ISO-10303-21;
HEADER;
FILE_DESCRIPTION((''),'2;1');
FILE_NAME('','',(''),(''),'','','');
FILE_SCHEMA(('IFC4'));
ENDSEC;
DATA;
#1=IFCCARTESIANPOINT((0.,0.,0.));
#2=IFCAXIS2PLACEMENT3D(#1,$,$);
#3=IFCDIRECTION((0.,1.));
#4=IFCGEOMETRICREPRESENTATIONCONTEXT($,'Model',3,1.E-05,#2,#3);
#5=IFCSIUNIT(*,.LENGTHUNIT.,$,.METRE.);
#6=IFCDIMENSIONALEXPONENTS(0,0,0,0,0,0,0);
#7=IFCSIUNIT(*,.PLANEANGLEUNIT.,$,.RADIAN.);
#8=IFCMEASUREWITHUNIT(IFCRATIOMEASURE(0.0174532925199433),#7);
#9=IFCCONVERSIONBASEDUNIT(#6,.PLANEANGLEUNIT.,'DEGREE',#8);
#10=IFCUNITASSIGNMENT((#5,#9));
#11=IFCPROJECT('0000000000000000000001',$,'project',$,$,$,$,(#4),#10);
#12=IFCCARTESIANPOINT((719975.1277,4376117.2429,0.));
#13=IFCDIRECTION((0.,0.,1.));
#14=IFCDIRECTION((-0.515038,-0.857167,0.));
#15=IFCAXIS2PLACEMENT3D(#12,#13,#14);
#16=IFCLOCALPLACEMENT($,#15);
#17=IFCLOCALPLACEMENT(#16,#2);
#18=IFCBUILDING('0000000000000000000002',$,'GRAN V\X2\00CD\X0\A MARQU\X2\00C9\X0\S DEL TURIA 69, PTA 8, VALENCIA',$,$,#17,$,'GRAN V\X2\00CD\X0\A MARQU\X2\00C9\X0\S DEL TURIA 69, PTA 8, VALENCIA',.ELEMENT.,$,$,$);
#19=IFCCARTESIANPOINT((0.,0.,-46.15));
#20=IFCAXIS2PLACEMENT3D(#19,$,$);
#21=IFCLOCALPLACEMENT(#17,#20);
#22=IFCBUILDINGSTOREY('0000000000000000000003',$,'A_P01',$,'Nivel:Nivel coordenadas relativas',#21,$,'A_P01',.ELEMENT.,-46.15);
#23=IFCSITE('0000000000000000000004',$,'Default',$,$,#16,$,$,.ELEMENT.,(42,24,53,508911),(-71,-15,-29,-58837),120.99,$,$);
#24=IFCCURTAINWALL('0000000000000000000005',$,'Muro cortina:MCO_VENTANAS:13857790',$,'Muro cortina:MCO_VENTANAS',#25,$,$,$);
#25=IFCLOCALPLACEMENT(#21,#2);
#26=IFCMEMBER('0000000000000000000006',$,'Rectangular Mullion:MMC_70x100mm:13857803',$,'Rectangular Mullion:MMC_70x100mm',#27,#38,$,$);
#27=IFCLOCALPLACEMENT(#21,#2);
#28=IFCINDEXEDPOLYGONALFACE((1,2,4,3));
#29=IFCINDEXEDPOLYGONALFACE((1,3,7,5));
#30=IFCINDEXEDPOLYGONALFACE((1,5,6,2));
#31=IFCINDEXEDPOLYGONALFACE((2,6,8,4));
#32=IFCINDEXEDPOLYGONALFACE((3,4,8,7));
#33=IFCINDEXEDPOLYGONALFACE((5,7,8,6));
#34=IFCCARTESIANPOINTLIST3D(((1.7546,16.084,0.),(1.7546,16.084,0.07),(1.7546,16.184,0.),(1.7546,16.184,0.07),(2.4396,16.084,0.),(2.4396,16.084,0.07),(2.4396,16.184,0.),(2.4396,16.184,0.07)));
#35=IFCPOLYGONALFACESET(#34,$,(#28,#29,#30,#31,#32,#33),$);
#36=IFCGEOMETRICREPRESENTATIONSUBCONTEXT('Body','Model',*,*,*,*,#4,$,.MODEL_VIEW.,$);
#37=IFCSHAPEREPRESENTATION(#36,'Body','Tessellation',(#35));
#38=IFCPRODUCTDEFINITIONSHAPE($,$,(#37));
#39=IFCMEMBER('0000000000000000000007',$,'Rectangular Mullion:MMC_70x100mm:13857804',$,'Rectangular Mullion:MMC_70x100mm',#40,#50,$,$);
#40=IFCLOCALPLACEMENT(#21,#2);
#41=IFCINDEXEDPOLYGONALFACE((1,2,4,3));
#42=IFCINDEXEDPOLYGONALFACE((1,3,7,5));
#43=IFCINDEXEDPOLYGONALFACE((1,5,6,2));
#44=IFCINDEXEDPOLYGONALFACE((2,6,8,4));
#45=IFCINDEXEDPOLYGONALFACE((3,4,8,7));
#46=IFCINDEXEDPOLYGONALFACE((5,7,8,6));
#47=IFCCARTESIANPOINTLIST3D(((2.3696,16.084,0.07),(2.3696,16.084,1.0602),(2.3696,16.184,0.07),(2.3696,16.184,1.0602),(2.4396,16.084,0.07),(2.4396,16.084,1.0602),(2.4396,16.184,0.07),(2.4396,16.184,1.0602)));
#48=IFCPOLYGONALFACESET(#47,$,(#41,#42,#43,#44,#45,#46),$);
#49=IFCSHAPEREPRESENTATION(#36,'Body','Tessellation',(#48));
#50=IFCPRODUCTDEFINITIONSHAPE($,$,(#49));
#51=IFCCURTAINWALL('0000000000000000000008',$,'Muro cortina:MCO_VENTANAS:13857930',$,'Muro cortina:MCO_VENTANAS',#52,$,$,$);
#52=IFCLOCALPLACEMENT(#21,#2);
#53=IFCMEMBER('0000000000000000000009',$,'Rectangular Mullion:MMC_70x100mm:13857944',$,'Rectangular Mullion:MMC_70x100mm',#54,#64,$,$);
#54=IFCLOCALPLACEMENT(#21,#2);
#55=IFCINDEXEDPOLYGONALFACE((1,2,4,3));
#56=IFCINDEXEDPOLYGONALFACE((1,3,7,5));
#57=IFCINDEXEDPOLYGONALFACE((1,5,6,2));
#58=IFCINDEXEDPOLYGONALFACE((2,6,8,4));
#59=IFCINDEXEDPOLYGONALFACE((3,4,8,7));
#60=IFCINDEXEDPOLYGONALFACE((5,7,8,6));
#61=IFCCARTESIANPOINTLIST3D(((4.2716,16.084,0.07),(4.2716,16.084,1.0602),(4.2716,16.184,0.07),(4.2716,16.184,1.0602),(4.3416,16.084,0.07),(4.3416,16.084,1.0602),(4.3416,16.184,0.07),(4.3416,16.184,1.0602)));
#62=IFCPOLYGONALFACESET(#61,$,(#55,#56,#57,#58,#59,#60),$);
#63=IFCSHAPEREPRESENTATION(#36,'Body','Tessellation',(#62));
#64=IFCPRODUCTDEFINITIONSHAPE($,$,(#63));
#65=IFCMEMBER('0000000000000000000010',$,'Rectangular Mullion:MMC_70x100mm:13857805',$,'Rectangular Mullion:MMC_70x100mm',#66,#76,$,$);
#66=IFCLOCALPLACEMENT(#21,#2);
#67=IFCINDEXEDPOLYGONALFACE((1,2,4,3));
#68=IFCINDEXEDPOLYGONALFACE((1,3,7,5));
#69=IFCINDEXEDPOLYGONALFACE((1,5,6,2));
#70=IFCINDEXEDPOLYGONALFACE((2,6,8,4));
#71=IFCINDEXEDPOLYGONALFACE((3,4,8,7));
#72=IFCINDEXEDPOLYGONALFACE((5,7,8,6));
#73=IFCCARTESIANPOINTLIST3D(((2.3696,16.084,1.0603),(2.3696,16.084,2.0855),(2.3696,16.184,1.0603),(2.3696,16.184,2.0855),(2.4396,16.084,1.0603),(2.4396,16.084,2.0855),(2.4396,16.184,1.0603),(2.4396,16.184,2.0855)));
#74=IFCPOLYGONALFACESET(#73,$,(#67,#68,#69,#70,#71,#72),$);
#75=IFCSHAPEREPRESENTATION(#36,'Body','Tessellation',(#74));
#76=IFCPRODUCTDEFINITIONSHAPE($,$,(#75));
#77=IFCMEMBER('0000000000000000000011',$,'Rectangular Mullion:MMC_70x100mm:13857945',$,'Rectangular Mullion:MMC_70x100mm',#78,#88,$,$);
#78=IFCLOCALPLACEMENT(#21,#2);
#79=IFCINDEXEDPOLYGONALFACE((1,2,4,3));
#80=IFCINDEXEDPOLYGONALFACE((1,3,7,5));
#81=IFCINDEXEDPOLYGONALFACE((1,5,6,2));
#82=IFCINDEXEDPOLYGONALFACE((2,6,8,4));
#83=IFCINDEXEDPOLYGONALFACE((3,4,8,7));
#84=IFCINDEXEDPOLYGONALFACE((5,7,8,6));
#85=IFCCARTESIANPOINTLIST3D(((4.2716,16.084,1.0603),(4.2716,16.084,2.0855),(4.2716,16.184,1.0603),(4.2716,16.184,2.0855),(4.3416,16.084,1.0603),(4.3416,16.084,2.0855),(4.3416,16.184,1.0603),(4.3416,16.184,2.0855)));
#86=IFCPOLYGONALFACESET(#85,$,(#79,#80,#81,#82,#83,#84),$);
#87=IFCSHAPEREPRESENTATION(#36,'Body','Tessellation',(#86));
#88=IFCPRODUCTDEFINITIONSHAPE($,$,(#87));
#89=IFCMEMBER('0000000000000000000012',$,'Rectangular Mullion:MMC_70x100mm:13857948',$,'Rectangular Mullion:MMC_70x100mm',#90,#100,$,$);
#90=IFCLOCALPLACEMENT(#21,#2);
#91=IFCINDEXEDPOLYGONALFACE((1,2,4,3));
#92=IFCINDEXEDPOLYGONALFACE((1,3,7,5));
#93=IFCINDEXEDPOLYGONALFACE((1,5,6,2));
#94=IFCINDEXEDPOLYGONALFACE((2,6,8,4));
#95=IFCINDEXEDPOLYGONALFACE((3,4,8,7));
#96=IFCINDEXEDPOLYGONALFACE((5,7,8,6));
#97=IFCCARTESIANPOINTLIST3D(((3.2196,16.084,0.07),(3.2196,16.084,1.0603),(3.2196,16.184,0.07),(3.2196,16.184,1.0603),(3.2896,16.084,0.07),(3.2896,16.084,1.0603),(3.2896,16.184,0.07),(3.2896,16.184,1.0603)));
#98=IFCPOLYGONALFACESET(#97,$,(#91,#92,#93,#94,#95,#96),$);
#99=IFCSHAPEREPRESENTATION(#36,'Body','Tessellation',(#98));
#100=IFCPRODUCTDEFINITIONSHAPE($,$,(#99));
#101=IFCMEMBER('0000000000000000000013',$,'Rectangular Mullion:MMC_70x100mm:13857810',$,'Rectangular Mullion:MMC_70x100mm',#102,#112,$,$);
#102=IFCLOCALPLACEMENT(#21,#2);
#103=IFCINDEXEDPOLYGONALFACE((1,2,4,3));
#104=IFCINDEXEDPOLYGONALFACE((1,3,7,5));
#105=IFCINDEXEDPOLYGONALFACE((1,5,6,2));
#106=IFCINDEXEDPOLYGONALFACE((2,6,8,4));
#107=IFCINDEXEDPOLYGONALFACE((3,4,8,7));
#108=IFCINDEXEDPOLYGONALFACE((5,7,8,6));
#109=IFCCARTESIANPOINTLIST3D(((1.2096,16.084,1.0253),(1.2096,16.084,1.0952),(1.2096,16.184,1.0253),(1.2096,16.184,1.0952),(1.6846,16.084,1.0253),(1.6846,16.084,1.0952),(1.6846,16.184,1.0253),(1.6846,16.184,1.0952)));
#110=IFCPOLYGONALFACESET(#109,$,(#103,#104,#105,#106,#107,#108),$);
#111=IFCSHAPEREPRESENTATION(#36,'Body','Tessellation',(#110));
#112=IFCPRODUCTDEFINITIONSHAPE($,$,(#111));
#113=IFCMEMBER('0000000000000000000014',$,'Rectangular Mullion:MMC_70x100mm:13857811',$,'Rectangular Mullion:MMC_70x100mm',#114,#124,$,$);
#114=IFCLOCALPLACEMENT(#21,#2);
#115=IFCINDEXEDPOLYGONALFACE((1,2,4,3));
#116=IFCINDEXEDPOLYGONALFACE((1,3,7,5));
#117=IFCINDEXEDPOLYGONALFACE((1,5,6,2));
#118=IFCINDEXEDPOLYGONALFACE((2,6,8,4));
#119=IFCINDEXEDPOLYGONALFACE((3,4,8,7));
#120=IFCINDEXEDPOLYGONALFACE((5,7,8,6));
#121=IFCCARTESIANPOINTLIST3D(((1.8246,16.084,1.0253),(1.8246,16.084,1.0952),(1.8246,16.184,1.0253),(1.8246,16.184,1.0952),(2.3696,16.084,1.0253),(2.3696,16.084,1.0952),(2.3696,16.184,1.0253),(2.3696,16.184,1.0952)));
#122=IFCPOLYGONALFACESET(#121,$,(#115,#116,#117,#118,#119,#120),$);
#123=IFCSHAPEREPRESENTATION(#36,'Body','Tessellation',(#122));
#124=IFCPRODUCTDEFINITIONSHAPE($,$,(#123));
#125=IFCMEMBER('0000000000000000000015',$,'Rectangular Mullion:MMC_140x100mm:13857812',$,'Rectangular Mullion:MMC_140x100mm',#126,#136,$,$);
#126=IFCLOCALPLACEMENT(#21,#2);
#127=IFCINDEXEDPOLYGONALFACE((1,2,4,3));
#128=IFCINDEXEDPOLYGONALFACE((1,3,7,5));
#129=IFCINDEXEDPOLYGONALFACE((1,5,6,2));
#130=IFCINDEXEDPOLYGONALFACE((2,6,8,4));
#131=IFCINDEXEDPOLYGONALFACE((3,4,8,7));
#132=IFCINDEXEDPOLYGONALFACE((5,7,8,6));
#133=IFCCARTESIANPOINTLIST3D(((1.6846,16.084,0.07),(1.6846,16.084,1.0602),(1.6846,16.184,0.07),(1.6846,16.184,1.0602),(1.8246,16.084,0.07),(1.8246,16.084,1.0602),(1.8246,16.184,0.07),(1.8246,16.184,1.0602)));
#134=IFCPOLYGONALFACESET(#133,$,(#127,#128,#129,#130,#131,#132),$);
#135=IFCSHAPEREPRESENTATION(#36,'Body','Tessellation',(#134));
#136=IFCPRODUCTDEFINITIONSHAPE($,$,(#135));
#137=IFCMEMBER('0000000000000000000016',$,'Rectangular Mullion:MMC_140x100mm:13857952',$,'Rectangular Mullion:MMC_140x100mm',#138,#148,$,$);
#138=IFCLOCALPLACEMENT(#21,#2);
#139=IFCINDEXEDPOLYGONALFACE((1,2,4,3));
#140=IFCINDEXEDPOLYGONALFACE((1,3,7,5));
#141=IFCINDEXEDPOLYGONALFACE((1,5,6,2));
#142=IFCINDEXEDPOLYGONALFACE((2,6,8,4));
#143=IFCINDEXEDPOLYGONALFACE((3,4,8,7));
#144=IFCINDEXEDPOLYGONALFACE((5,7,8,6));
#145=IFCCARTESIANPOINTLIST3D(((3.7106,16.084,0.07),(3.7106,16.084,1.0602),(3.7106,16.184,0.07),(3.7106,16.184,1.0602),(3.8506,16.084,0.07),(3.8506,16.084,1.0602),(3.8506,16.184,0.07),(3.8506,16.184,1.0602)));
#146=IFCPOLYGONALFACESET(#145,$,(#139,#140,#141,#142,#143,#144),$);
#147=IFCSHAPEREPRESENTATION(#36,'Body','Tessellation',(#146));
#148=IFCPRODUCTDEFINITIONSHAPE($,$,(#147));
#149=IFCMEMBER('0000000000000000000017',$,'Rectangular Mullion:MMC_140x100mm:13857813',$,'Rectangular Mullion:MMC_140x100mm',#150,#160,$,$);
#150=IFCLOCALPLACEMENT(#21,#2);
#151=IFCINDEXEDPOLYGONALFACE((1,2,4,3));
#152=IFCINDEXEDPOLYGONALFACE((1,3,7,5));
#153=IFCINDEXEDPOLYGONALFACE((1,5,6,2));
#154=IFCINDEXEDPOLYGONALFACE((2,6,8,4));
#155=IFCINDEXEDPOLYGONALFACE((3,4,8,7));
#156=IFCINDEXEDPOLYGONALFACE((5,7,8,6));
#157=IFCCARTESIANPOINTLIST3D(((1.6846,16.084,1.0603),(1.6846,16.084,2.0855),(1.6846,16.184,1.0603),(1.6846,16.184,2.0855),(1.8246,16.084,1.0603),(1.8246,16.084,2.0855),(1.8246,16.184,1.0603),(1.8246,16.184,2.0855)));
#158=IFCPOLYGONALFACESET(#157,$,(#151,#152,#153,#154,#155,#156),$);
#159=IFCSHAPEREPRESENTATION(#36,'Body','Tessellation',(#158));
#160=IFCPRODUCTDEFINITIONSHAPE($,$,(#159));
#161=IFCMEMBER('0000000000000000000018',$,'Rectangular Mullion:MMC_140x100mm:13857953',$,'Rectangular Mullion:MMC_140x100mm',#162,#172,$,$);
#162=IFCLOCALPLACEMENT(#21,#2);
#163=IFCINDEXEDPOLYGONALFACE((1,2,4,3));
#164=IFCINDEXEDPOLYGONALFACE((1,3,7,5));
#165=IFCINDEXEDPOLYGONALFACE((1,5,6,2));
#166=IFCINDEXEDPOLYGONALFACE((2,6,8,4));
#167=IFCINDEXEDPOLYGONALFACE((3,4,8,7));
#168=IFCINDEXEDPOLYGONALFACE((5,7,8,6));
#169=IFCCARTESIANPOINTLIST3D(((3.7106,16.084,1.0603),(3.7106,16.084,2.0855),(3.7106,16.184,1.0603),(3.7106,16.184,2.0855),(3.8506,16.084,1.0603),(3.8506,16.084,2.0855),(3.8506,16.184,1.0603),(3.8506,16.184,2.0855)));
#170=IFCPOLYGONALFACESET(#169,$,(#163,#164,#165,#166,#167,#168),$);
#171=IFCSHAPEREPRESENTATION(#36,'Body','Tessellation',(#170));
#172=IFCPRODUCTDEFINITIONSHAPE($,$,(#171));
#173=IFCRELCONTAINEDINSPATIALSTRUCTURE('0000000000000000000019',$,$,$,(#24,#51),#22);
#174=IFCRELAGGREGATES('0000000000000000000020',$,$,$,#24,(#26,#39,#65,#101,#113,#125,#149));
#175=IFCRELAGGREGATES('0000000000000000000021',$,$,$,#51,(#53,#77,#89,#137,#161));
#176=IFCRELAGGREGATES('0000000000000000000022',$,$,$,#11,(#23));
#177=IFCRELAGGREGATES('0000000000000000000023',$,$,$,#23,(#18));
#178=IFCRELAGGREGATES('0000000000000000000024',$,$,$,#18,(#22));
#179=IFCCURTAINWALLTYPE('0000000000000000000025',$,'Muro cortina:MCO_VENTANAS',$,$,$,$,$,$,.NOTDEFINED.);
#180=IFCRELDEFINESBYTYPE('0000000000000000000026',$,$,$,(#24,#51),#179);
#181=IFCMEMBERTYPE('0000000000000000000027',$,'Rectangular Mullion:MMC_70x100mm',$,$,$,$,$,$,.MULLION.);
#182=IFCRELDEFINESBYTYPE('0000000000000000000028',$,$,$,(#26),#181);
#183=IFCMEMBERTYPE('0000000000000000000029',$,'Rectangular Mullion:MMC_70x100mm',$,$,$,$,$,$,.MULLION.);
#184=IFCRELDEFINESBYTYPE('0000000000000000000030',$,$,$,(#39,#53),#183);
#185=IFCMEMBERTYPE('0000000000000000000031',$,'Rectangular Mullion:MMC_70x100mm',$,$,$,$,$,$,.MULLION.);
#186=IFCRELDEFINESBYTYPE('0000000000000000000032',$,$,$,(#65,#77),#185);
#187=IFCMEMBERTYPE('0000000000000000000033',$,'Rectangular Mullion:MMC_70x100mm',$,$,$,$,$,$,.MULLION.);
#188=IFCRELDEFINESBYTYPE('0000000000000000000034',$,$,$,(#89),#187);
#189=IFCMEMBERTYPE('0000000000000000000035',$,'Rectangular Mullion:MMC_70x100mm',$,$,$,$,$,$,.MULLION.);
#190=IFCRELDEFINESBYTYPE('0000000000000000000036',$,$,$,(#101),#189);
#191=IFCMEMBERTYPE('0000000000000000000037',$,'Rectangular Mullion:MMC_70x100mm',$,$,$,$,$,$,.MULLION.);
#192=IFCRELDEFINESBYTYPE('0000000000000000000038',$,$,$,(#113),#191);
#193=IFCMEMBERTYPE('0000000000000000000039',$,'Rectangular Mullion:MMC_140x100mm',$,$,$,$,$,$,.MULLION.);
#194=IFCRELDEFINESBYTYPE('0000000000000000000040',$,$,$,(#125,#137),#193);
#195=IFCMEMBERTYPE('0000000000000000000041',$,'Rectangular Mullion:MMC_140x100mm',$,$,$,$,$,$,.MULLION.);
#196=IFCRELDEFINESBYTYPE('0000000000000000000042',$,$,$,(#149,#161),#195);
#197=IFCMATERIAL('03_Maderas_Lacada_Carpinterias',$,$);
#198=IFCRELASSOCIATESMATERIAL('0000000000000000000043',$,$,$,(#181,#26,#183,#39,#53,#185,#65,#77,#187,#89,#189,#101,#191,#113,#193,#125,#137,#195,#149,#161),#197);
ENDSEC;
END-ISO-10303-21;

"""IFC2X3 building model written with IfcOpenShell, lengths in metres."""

from ifc_helpers import new_model, entity, si_unit, converted_unit, direction, frame, origin, origin_2d_with_axis, place, context, subcontext, project, spatial, rectangle, extrude, source, transform, mapped, material, type_object, type_shapes, element, aggregate, save


model = new_model("IFC2X3")

# Units and contexts
model_context = context("Model", 3, precision=1e-05, world=origin(), true_north=direction((0.0, 1.0)))
body_context = subcontext(model_context, "Body", "Model", "MODEL_VIEW")
ifc_project = project(units=[si_unit("LENGTHUNIT", "METRE"), converted_unit("PLANEANGLEUNIT", "DEGREE", entity("IfcRatioMeasure", 0.0174532925199433), si_unit("PLANEANGLEUNIT", "RADIAN"), dimensions=[0, 0, 0, 0, 0, 0, 0])], contexts=[model_context])

# Site, building, storey
site_placement = place(None, frame((719975.1277, 4376117.2429, 0.0), z_axis=(0.0, 0.0, 1.0), x_axis=(-0.515038, -0.857167, 0.0)))
site = spatial("IfcSite", under=ifc_project, at=site_placement, Name="Default", CompositionType="ELEMENT", RefLatitude=(42, 24, 53, 508911), RefLongitude=(-71, -15, -29, -58837), RefElevation=120.99)
building_placement = place(site_placement, origin())
building = spatial("IfcBuilding", under=site, at=building_placement, Name="GRAN VÍA MARQUÉS DEL TURIA 69, PTA 8, VALENCIA", LongName="GRAN VÍA MARQUÉS DEL TURIA 69, PTA 8, VALENCIA", CompositionType="ELEMENT")
storey_placement = place(building_placement, frame((0.0, 0.0, -46.15)))
storey = spatial("IfcBuildingStorey", under=building, at=storey_placement, Name="A_P01", ObjectType="Nivel:Nivel coordenadas relativas", LongName="A_P01", CompositionType="ELEMENT", Elevation=-46.15)

# Curtain wall, members
curtain_wall_type = type_object("IfcCurtainWallType", Name="Muro cortina:MCO_VENTANAS", PredefinedType="NOTDEFINED")
curtain_wall_1_placement = place(storey_placement, frame((0.0, 0.0, 46.15)))
curtain_wall_1 = element("IfcCurtainWall", 1, at=curtain_wall_1_placement, inside=storey, type_object=curtain_wall_type, Name="Muro cortina:MCO_VENTANAS:13857790", ObjectType="Muro cortina:MCO_VENTANAS")
ifc_material_1 = material(Name="03_Maderas_Lacada_Carpinterias")
member_type_1 = type_object("IfcMemberType", Name="Rectangular Mullion:MMC_70x100mm", PredefinedType="MULLION", material=ifc_material_1)
shared_shape_1 = source(origin(), body_context, "Body", "SweptSolid", [
    extrude(rectangle(XDim=0.1, YDim=0.07, at=origin_2d_with_axis()), frame((-0.035, 0.0, -0.685), z_axis=(0.0, 0.0, 1.0), x_axis=(0.0, -1.0, 0.0)), (0.0, 0.0, 1.0), 0.685),
])
type_shapes(member_type_1, [shared_shape_1])
member_1_placement = place(storey_placement, frame((1.7546, 16.134, 0.0), z_axis=(-1.0, 0.0, 0.0), x_axis=(0.0, 0.0, -1.0)))
member_1 = element("IfcMember", 2, at=member_1_placement, type_object=member_type_1, material=ifc_material_1, Name="Rectangular Mullion:MMC_70x100mm:13857803", ObjectType="Rectangular Mullion:MMC_70x100mm", context=body_context, shape_type="MappedRepresentation", body=[
    mapped(shared_shape_1, transform((0.0, 0.0, 0.0), scale=1.0)),
])
member_type_2 = type_object("IfcMemberType", Name="Rectangular Mullion:MMC_70x100mm", PredefinedType="MULLION", material=ifc_material_1)
shared_shape_2 = source(origin(), body_context, "Body", "SweptSolid", [
    extrude(rectangle(XDim=0.1, YDim=0.07, at=origin_2d_with_axis()), frame((-0.035, 0.0, -0.9902), z_axis=(0.0, 0.0, 1.0), x_axis=(0.0, -1.0, 0.0)), (0.0, 0.0, 1.0), 0.9902),
])
type_shapes(member_type_2, [shared_shape_2])
member_2_placement = place(storey_placement, frame((2.4396, 16.134, 0.07), z_axis=(0.0, 0.0, -1.0), x_axis=(1.0, 0.0, 0.0)))
member_2 = element("IfcMember", 3, at=member_2_placement, type_object=member_type_2, material=ifc_material_1, Name="Rectangular Mullion:MMC_70x100mm:13857804", ObjectType="Rectangular Mullion:MMC_70x100mm", context=body_context, shape_type="MappedRepresentation", body=[
    mapped(shared_shape_2, transform((0.0, 0.0, 0.0), scale=1.0)),
])

# Curtain wall, member
curtain_wall_2_placement = place(storey_placement, frame((0.0, 0.0, 46.15)))
curtain_wall_2 = element("IfcCurtainWall", 4, at=curtain_wall_2_placement, inside=storey, type_object=curtain_wall_type, Name="Muro cortina:MCO_VENTANAS:13857930", ObjectType="Muro cortina:MCO_VENTANAS")
member_3_placement = place(storey_placement, frame((4.3416, 16.134, 0.07), z_axis=(0.0, 0.0, -1.0), x_axis=(1.0, 0.0, 0.0)))
member_3 = element("IfcMember", 5, at=member_3_placement, type_object=member_type_2, material=ifc_material_1, Name="Rectangular Mullion:MMC_70x100mm:13857944", ObjectType="Rectangular Mullion:MMC_70x100mm", context=body_context, shape_type="MappedRepresentation", body=[
    mapped(shared_shape_2, transform((0.0, 0.0, 0.0), scale=1.0)),
])

# Members
member_type_3 = type_object("IfcMemberType", Name="Rectangular Mullion:MMC_70x100mm", PredefinedType="MULLION", material=ifc_material_1)
shared_shape_3 = source(origin(), body_context, "Body", "SweptSolid", [
    extrude(rectangle(XDim=0.1, YDim=0.07, at=origin_2d_with_axis()), frame((-0.035, 0.0, -1.0252), z_axis=(0.0, 0.0, 1.0), x_axis=(0.0, -1.0, 0.0)), (0.0, 0.0, 1.0), 1.0252),
])
type_shapes(member_type_3, [shared_shape_3])
member_4_placement = place(storey_placement, frame((2.4396, 16.134, 1.0602), z_axis=(0.0, 0.0, -1.0), x_axis=(1.0, 0.0, 0.0)))
member_4 = element("IfcMember", 6, at=member_4_placement, type_object=member_type_3, material=ifc_material_1, Name="Rectangular Mullion:MMC_70x100mm:13857805", ObjectType="Rectangular Mullion:MMC_70x100mm", context=body_context, shape_type="MappedRepresentation", body=[
    mapped(shared_shape_3, transform((0.0, 0.0, 0.0), scale=1.0)),
])
member_5_placement = place(storey_placement, frame((4.3416, 16.134, 1.0602), z_axis=(0.0, 0.0, -1.0), x_axis=(1.0, 0.0, 0.0)))
member_5 = element("IfcMember", 7, at=member_5_placement, type_object=member_type_3, material=ifc_material_1, Name="Rectangular Mullion:MMC_70x100mm:13857945", ObjectType="Rectangular Mullion:MMC_70x100mm", context=body_context, shape_type="MappedRepresentation", body=[
    mapped(shared_shape_3, transform((0.0, 0.0, 0.0), scale=1.0)),
])
member_type_4 = type_object("IfcMemberType", Name="Rectangular Mullion:MMC_70x100mm", PredefinedType="MULLION", material=ifc_material_1)
shared_shape_4 = source(origin(), body_context, "Body", "SweptSolid", [
    extrude(rectangle(XDim=0.1, YDim=0.07, at=origin_2d_with_axis()), frame((-0.035, 0.0, -0.9902), z_axis=(0.0, 0.0, 1.0), x_axis=(0.0, -1.0, 0.0)), (0.0, 0.0, 1.0), 0.9902),
])
type_shapes(member_type_4, [shared_shape_4])
member_6_placement = place(storey_placement, frame((3.2196, 16.134, 1.0602), z_axis=(0.0, 0.0, 1.0), x_axis=(-1.0, 0.0, 0.0)))
member_6 = element("IfcMember", 8, at=member_6_placement, type_object=member_type_4, material=ifc_material_1, Name="Rectangular Mullion:MMC_70x100mm:13857948", ObjectType="Rectangular Mullion:MMC_70x100mm", context=body_context, shape_type="MappedRepresentation", body=[
    mapped(shared_shape_4, transform((0.0, 0.0, 0.0), scale=1.0)),
])
member_type_5 = type_object("IfcMemberType", Name="Rectangular Mullion:MMC_70x100mm", PredefinedType="MULLION", material=ifc_material_1)
shared_shape_5 = source(origin(), body_context, "Body", "SweptSolid", [
    extrude(rectangle(XDim=0.1, YDim=0.07, at=origin_2d_with_axis()), frame((0.0, 0.0, -0.475), z_axis=(0.0, 0.0, 1.0), x_axis=(0.0, -1.0, 0.0)), (0.0, 0.0, 1.0), 0.475),
])
type_shapes(member_type_5, [shared_shape_5])
member_7_placement = place(storey_placement, frame((1.6846, 16.134, 1.0602), z_axis=(1.0, 0.0, 0.0), x_axis=(0.0, 0.0, 1.0)))
member_7 = element("IfcMember", 9, at=member_7_placement, type_object=member_type_5, material=ifc_material_1, Name="Rectangular Mullion:MMC_70x100mm:13857810", ObjectType="Rectangular Mullion:MMC_70x100mm", context=body_context, shape_type="MappedRepresentation", body=[
    mapped(shared_shape_5, transform((0.0, 0.0, 0.0), scale=1.0)),
])
member_type_6 = type_object("IfcMemberType", Name="Rectangular Mullion:MMC_70x100mm", PredefinedType="MULLION", material=ifc_material_1)
shared_shape_6 = source(origin(), body_context, "Body", "SweptSolid", [
    extrude(rectangle(XDim=0.1, YDim=0.07, at=origin_2d_with_axis()), frame((0.0, 0.0, -0.545), z_axis=(0.0, 0.0, 1.0), x_axis=(0.0, -1.0, 0.0)), (0.0, 0.0, 1.0), 0.545),
])
type_shapes(member_type_6, [shared_shape_6])
member_8_placement = place(storey_placement, frame((2.3696, 16.134, 1.0602), z_axis=(1.0, 0.0, 0.0), x_axis=(0.0, 0.0, 1.0)))
member_8 = element("IfcMember", 10, at=member_8_placement, type_object=member_type_6, material=ifc_material_1, Name="Rectangular Mullion:MMC_70x100mm:13857811", ObjectType="Rectangular Mullion:MMC_70x100mm", context=body_context, shape_type="MappedRepresentation", body=[
    mapped(shared_shape_6, transform((0.0, 0.0, 0.0), scale=1.0)),
])
member_type_7 = type_object("IfcMemberType", Name="Rectangular Mullion:MMC_140x100mm", PredefinedType="MULLION", material=ifc_material_1)
shared_shape_7 = source(origin(), body_context, "Body", "SweptSolid", [
    extrude(rectangle(XDim=0.1, YDim=0.14, at=origin_2d_with_axis()), frame((0.0, 0.0, -0.9902), z_axis=(0.0, 0.0, 1.0), x_axis=(0.0, -1.0, 0.0)), (0.0, 0.0, 1.0), 0.9902),
])
type_shapes(member_type_7, [shared_shape_7])
member_9_placement = place(storey_placement, frame((1.7546, 16.134, 0.07), z_axis=(0.0, 0.0, -1.0), x_axis=(1.0, 0.0, 0.0)))
member_9 = element("IfcMember", 11, at=member_9_placement, type_object=member_type_7, material=ifc_material_1, Name="Rectangular Mullion:MMC_140x100mm:13857812", ObjectType="Rectangular Mullion:MMC_140x100mm", context=body_context, shape_type="MappedRepresentation", body=[
    mapped(shared_shape_7, transform((0.0, 0.0, 0.0), scale=1.0)),
])
member_10_placement = place(storey_placement, frame((3.7806, 16.134, 0.07), z_axis=(0.0, 0.0, -1.0), x_axis=(1.0, 0.0, 0.0)))
member_10 = element("IfcMember", 12, at=member_10_placement, type_object=member_type_7, material=ifc_material_1, Name="Rectangular Mullion:MMC_140x100mm:13857952", ObjectType="Rectangular Mullion:MMC_140x100mm", context=body_context, shape_type="MappedRepresentation", body=[
    mapped(shared_shape_7, transform((0.0, 0.0, 0.0), scale=1.0)),
])
member_type_8 = type_object("IfcMemberType", Name="Rectangular Mullion:MMC_140x100mm", PredefinedType="MULLION", material=ifc_material_1)
shared_shape_8 = source(origin(), body_context, "Body", "SweptSolid", [
    extrude(rectangle(XDim=0.1, YDim=0.14, at=origin_2d_with_axis()), frame((0.0, 0.0, -1.0252), z_axis=(0.0, 0.0, 1.0), x_axis=(0.0, -1.0, 0.0)), (0.0, 0.0, 1.0), 1.0252),
])
type_shapes(member_type_8, [shared_shape_8])
member_11_placement = place(storey_placement, frame((1.7546, 16.134, 1.0602), z_axis=(0.0, 0.0, -1.0), x_axis=(1.0, 0.0, 0.0)))
member_11 = element("IfcMember", 13, at=member_11_placement, type_object=member_type_8, material=ifc_material_1, Name="Rectangular Mullion:MMC_140x100mm:13857813", ObjectType="Rectangular Mullion:MMC_140x100mm", context=body_context, shape_type="MappedRepresentation", body=[
    mapped(shared_shape_8, transform((0.0, 0.0, 0.0), scale=1.0)),
])
member_12_placement = place(storey_placement, frame((3.7806, 16.134, 1.0602), z_axis=(0.0, 0.0, -1.0), x_axis=(1.0, 0.0, 0.0)))
member_12 = element("IfcMember", 14, at=member_12_placement, type_object=member_type_8, material=ifc_material_1, Name="Rectangular Mullion:MMC_140x100mm:13857953", ObjectType="Rectangular Mullion:MMC_140x100mm", context=body_context, shape_type="MappedRepresentation", body=[
    mapped(shared_shape_8, transform((0.0, 0.0, 0.0), scale=1.0)),
])

aggregate(curtain_wall_1, [member_1, member_2, member_4, member_7, member_8, member_9, member_11])
aggregate(curtain_wall_2, [member_3, member_5, member_6, member_10, member_12])

save(model, "model.ifc")
